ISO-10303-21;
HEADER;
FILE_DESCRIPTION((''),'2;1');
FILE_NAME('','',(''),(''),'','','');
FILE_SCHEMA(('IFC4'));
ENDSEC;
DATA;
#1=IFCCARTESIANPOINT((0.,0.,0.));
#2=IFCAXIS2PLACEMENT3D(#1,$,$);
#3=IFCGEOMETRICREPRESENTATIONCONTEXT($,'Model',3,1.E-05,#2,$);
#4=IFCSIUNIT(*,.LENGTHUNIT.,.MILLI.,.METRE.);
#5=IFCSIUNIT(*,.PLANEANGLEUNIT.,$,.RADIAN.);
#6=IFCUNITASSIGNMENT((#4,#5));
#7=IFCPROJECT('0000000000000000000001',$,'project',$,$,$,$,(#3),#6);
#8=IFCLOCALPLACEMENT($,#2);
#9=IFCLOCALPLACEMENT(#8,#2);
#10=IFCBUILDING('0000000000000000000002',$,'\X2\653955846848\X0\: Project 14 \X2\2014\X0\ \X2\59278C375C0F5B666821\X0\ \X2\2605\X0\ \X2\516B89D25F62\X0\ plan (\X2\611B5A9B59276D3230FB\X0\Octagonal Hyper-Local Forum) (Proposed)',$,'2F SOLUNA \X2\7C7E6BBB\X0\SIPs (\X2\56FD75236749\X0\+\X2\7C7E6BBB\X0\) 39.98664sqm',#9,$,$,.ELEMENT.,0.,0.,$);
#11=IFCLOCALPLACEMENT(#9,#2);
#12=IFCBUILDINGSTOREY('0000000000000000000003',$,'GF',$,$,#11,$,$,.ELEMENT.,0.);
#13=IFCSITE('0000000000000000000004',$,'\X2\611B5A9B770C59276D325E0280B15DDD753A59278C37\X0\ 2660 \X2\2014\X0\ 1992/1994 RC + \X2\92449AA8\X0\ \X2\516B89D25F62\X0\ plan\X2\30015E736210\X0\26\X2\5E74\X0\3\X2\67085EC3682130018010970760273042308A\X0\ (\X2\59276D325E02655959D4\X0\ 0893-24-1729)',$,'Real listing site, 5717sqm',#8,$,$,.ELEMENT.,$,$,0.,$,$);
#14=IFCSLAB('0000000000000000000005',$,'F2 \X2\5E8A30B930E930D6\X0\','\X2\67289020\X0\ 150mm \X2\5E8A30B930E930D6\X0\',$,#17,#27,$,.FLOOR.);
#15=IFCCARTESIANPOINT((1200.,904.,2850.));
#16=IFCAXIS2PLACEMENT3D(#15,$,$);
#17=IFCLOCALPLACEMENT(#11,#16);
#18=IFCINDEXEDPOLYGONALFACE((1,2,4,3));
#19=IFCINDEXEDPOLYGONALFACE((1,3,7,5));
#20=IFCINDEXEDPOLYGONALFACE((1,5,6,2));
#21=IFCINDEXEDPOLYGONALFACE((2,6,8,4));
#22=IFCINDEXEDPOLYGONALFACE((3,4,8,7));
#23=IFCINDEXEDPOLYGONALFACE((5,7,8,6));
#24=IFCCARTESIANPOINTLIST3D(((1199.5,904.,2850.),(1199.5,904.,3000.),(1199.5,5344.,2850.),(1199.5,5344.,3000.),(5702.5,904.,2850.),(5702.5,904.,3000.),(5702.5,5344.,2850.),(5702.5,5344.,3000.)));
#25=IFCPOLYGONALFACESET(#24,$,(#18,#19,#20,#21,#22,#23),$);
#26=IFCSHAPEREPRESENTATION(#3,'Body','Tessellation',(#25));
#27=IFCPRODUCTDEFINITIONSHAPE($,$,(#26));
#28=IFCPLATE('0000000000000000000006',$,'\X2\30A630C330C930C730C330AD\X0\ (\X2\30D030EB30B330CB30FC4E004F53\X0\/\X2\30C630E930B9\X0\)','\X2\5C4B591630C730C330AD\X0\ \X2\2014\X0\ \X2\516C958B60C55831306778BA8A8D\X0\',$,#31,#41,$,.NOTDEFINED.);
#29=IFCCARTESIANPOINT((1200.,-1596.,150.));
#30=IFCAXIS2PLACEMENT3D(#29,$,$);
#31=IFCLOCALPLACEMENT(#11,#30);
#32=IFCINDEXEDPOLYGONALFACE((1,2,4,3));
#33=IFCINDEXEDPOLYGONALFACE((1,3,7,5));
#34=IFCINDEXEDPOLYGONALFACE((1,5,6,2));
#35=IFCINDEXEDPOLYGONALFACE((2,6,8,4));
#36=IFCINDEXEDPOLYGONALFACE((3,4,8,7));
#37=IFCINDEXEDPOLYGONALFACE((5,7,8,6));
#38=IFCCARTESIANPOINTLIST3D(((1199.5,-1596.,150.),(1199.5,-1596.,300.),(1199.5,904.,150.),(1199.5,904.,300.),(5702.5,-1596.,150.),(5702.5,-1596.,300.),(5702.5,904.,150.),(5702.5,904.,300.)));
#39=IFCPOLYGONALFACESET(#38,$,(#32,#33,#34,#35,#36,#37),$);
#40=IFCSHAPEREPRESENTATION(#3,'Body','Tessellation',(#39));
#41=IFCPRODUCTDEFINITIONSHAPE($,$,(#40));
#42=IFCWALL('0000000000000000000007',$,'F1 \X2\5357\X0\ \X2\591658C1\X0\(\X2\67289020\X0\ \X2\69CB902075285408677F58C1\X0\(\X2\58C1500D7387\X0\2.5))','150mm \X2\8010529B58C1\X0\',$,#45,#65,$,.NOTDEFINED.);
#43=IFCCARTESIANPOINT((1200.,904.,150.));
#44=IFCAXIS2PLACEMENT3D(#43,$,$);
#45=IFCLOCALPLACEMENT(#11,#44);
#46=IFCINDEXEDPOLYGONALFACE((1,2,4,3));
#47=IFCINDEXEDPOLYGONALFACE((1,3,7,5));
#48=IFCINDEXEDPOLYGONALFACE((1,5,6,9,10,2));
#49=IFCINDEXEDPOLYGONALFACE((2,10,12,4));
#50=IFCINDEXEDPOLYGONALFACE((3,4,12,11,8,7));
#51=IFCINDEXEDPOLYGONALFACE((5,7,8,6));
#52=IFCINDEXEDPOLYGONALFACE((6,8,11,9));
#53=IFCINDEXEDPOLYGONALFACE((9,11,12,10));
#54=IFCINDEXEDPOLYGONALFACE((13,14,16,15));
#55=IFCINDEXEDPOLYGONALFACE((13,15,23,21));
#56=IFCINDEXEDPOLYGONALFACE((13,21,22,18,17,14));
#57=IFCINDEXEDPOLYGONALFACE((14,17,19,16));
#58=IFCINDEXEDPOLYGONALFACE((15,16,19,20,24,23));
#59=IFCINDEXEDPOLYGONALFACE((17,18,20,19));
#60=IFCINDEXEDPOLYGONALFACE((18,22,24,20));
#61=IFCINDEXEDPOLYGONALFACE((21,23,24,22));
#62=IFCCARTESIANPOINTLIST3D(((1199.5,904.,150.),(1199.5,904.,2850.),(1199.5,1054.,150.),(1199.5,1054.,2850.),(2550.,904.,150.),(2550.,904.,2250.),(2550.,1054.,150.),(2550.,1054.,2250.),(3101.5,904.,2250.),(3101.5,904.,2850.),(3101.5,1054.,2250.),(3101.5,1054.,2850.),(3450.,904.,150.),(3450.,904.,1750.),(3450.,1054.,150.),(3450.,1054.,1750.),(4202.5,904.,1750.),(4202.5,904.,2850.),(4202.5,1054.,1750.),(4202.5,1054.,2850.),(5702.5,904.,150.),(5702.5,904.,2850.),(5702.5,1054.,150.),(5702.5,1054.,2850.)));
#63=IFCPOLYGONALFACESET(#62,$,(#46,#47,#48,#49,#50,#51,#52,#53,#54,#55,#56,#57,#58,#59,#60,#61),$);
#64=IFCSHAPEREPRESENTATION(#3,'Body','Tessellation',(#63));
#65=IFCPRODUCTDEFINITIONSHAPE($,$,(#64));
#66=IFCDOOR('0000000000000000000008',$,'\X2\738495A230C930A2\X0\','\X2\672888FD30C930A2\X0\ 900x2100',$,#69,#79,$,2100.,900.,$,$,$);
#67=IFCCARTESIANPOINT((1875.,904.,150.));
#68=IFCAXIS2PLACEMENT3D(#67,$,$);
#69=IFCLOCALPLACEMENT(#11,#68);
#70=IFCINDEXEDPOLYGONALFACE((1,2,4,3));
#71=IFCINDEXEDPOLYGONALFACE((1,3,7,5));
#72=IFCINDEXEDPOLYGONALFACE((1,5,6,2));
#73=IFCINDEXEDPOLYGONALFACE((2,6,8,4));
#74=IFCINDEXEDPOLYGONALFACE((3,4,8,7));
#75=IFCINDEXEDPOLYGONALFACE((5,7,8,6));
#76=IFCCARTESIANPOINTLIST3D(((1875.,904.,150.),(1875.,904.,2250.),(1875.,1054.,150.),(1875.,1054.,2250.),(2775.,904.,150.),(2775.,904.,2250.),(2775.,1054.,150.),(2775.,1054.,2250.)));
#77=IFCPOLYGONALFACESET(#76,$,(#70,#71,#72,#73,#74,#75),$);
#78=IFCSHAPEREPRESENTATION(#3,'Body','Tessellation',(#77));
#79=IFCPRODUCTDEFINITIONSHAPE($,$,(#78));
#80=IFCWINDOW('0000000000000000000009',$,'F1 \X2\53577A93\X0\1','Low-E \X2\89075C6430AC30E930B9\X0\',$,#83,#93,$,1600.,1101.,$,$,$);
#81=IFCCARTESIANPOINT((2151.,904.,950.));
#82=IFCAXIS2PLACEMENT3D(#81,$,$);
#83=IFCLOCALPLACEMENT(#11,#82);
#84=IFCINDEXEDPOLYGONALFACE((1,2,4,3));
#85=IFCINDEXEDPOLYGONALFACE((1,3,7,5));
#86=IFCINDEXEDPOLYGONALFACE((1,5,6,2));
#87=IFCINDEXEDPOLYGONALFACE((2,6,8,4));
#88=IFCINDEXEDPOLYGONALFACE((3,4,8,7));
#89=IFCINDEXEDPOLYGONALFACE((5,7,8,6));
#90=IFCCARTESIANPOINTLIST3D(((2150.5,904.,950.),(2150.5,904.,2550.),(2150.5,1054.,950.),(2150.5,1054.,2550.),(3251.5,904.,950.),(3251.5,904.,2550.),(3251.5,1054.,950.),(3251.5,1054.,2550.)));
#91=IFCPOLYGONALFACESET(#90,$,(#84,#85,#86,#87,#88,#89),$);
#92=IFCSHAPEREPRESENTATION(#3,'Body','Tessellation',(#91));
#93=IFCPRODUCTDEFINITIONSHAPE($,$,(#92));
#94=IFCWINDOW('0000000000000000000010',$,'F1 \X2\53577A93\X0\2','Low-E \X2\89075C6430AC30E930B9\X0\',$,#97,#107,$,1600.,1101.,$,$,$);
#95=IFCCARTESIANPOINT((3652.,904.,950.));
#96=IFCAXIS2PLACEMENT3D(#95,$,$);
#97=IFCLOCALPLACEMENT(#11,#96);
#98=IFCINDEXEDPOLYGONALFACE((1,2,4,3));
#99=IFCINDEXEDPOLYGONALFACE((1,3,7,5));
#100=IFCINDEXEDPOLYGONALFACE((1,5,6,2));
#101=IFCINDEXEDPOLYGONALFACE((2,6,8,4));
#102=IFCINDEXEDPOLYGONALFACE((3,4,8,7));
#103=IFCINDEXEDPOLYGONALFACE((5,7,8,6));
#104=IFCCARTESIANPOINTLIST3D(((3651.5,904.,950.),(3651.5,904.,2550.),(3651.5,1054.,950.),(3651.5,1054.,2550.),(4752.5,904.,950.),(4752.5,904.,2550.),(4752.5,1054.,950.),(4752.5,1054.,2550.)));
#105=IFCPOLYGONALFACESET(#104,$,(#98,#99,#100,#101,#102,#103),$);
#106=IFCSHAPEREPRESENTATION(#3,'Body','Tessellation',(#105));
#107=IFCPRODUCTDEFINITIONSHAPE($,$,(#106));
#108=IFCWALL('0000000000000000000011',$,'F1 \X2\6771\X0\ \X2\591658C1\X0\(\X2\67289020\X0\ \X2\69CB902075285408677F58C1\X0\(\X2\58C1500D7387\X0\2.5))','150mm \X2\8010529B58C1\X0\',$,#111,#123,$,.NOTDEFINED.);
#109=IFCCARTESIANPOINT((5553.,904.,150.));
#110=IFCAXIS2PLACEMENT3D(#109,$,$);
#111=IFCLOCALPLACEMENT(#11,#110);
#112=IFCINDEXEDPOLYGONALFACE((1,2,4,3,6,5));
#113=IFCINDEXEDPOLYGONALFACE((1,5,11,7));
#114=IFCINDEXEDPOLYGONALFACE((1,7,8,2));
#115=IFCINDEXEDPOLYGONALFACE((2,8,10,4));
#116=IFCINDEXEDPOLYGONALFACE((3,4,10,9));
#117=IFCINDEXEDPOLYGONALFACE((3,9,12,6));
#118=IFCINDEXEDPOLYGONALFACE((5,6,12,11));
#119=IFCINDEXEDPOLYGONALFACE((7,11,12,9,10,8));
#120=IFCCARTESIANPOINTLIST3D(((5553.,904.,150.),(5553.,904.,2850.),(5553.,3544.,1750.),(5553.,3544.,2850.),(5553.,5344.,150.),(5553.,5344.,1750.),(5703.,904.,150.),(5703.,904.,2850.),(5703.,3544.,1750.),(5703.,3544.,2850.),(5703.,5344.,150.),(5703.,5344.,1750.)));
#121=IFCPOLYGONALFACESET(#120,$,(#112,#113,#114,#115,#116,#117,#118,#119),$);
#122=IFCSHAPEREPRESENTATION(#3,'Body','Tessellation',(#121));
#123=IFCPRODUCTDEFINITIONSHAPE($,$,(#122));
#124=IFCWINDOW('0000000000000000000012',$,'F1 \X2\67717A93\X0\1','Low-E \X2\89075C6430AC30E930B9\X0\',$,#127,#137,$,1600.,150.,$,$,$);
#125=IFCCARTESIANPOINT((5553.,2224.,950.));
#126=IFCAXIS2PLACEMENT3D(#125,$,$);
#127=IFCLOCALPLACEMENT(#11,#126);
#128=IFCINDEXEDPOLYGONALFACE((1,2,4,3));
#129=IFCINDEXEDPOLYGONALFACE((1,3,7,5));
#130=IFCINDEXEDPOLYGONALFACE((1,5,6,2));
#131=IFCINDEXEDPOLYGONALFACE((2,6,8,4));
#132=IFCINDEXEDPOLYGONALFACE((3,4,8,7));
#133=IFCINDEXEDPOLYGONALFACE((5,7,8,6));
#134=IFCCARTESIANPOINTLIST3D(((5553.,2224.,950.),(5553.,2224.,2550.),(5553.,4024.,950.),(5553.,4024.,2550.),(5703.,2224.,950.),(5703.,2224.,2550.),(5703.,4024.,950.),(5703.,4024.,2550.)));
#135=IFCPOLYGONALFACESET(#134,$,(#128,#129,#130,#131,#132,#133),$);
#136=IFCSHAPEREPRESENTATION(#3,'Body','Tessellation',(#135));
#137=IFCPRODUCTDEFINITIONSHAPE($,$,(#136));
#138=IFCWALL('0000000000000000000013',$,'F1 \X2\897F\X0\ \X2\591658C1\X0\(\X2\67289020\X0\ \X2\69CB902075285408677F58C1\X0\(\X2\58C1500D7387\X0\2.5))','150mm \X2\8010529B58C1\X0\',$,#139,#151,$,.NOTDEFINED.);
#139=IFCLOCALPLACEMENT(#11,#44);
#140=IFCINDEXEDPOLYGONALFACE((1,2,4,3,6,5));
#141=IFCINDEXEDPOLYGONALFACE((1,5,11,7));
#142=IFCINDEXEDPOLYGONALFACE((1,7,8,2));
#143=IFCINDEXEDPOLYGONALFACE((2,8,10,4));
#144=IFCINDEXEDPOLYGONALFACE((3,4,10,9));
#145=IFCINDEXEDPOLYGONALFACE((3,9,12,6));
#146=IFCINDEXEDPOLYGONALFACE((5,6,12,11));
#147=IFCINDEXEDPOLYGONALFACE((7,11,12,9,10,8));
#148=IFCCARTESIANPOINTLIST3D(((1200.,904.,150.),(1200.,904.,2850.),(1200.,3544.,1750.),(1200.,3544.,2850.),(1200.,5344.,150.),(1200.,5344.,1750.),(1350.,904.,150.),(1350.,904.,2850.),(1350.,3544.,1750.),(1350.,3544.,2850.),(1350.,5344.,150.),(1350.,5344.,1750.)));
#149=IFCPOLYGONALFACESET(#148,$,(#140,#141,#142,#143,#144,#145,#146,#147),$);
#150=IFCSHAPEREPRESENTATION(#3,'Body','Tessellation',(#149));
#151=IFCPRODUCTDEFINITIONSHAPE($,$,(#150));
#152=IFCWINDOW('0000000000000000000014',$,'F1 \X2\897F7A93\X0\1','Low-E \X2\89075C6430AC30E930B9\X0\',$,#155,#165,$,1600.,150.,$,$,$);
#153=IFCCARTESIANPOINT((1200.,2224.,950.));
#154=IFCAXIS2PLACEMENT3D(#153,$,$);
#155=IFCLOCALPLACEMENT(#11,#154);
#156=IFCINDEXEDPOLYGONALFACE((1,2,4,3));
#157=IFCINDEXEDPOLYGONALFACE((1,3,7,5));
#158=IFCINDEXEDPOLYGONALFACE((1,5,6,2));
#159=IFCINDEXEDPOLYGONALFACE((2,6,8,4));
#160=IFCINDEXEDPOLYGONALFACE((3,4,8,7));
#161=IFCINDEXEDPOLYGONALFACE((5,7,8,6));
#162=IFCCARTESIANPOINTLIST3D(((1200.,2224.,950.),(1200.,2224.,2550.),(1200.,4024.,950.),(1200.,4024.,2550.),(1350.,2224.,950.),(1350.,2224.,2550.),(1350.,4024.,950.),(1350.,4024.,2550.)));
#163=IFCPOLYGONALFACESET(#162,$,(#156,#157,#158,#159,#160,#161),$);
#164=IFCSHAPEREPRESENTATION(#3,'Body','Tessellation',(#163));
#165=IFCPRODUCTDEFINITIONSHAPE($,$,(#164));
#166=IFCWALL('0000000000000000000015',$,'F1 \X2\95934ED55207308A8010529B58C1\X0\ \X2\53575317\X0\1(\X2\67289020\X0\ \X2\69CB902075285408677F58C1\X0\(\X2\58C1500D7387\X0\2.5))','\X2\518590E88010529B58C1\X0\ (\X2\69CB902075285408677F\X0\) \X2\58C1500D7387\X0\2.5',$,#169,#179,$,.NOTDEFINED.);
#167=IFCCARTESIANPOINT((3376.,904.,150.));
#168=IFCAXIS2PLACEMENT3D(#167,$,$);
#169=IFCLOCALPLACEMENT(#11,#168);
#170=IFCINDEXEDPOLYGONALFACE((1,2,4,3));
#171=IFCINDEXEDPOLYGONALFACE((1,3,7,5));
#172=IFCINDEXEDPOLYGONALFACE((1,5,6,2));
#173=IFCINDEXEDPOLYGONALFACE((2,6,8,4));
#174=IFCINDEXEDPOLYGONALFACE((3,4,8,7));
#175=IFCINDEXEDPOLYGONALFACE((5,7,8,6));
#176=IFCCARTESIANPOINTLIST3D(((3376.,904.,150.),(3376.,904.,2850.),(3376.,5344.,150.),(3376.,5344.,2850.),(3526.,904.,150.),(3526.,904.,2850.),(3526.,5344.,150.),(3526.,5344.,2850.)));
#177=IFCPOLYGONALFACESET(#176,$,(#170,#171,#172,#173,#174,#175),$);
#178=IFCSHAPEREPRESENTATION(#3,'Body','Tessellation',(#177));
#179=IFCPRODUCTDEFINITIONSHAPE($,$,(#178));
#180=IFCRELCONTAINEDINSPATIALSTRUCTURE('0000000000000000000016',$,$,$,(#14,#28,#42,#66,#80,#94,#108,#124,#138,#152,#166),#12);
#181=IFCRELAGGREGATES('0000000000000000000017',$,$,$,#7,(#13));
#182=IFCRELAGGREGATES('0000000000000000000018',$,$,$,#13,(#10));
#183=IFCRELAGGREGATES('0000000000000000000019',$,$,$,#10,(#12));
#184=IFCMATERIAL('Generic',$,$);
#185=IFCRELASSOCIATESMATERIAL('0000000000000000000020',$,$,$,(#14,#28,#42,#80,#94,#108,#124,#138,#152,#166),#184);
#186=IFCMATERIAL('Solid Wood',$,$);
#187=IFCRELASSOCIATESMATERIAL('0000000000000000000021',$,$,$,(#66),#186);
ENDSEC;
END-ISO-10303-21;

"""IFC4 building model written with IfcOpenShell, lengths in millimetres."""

from ifc_helpers import new_model, si_unit, frame, frame_2d, origin, place, context, project, spatial, rectangle, extrude, material, element, fill, save


model = new_model("IFC4")

# Units and contexts
model_context = context("Model", 3, precision=1e-05, world=origin())
ifc_project = project(units=[si_unit("LENGTHUNIT", "METRE", prefix="MILLI"), si_unit("PLANEANGLEUNIT", "RADIAN")], contexts=[model_context])

# Site, building, storey
site_placement = place(None, origin())
site = spatial("IfcSite", under=ifc_project, at=site_placement, Name="愛媛県大洲市肱川町大谷 2660 — 1992/1994 RC + 鉄骨 八角形 plan、平成26年3月廃校、耐震性あり (大洲市教委 0893-24-1729)", ObjectType="Real listing site, 5717sqm", CompositionType="ELEMENT", RefElevation=0.0)
building_placement = place(site_placement, origin())
building = spatial("IfcBuilding", under=site, at=building_placement, Name="改善案: Project 14 — 大谷小学校 ★ 八角形 plan (愛媛大洲・Octagonal Hyper-Local Forum) (Proposed)", ObjectType="2F SOLUNA 籾殻SIPs (国産杉+籾殻) 39.98664sqm", CompositionType="ELEMENT", ElevationOfRefHeight=0.0, ElevationOfTerrain=0.0)
storey_placement = place(building_placement, origin())
storey = spatial("IfcBuildingStorey", under=building, at=storey_placement, Name="GF", CompositionType="ELEMENT", Elevation=0.0)

# Slab
ifc_material_1 = material(Name="Generic")
slab_1_placement = place(storey_placement, frame((1200.0, 904.0, 2850.0)))
element("IfcSlab", 1, at=slab_1_placement, inside=storey, material=ifc_material_1, Name="F2 床スラブ", Description="木造 150mm 床スラブ", PredefinedType="FLOOR", context=model_context, shape_type="SweptSolid", body=[
    extrude(rectangle(XDim=4503.0, YDim=4440.0, at=frame_2d((2251.0, 2220.0))), frame((1200.0, 904.0, 2850.0)), (0.0, 0.0, 1.0), 150.0),
])

# Plate
plate_placement = place(storey_placement, frame((1200.0, -1596.0, 150.0)))
element("IfcPlate", 2, at=plate_placement, inside=storey, material=ifc_material_1, Name="ウッドデッキ (バルコニー一体/テラス)", Description="屋外デッキ — 公開情報で確認", PredefinedType="NOTDEFINED", context=model_context, shape_type="SweptSolid", body=[
    extrude(rectangle(XDim=4503.0, YDim=2500.0, at=frame_2d((2251.0, 1250.0))), frame((1200.0, -1596.0, 150.0)), (0.0, 0.0, 1.0), 150.0),
])

# Wall, openings, door, windows
wall_1_placement = place(storey_placement, frame((1200.0, 904.0, 150.0)))
wall_1 = element("IfcWall", 3, at=wall_1_placement, inside=storey, material=ifc_material_1, Name="F1 南 外壁(木造 構造用合板壁(壁倍率2.5))", Description="150mm 耐力壁", PredefinedType="NOTDEFINED", context=model_context, shape_type="SweptSolid", body=[
    extrude(rectangle(XDim=4503.0, YDim=150.0, at=frame_2d((2251.0, 75.0))), frame((1200.0, 904.0, 150.0)), (0.0, 0.0, 1.0), 2700.0),
])
opening_1_placement = place(storey_placement, frame((1875.0, 904.0, 150.0)))
opening_1 = element("IfcOpeningElement", 4, at=opening_1_placement, cuts=wall_1, PredefinedType="NOTDEFINED", context=model_context, shape_type="SweptSolid", body=[
    extrude(rectangle(XDim=900.0, YDim=150.0, at=frame_2d((450.0, 75.0))), frame((1875.0, 904.0, 150.0)), (0.0, 0.0, 1.0), 2100.0),
])
opening_2_placement = place(storey_placement, frame((2151.0, 904.0, 950.0)))
opening_2 = element("IfcOpeningElement", 5, at=opening_2_placement, cuts=wall_1, PredefinedType="NOTDEFINED", context=model_context, shape_type="SweptSolid", body=[
    extrude(rectangle(XDim=1101.0, YDim=150.0, at=frame_2d((550.0, 75.0))), frame((2151.0, 904.0, 950.0)), (0.0, 0.0, 1.0), 1600.0),
])
opening_3_placement = place(storey_placement, frame((3652.0, 904.0, 950.0)))
opening_3 = element("IfcOpeningElement", 6, at=opening_3_placement, cuts=wall_1, PredefinedType="NOTDEFINED", context=model_context, shape_type="SweptSolid", body=[
    extrude(rectangle(XDim=1101.0, YDim=150.0, at=frame_2d((550.0, 75.0))), frame((3652.0, 904.0, 950.0)), (0.0, 0.0, 1.0), 1600.0),
])
ifc_material_2 = material(Name="Solid Wood")
door_placement = place(storey_placement, frame((1875.0, 904.0, 150.0)))
door = element("IfcDoor", 7, at=door_placement, inside=storey, material=ifc_material_2, Name="玄関ドア", Description="木製ドア 900x2100", OverallHeight=2100.0, OverallWidth=900.0, context=model_context, shape_type="SweptSolid", body=[
    extrude(rectangle(XDim=900.0, YDim=150.0, at=frame_2d((450.0, 75.0))), frame((1875.0, 904.0, 150.0)), (0.0, 0.0, 1.0), 2100.0),
])
fill(opening_1, door)
window_1_placement = place(storey_placement, frame((2151.0, 904.0, 950.0)))
window_1 = element("IfcWindow", 8, at=window_1_placement, inside=storey, material=ifc_material_1, Name="F1 南窓1", Description="Low-E 複層ガラス", OverallHeight=1600.0, OverallWidth=1101.0, context=model_context, shape_type="SweptSolid", body=[
    extrude(rectangle(XDim=1101.0, YDim=150.0, at=frame_2d((550.0, 75.0))), frame((2151.0, 904.0, 950.0)), (0.0, 0.0, 1.0), 1600.0),
])
fill(opening_2, window_1)
window_2_placement = place(storey_placement, frame((3652.0, 904.0, 950.0)))
window_2 = element("IfcWindow", 9, at=window_2_placement, inside=storey, material=ifc_material_1, Name="F1 南窓2", Description="Low-E 複層ガラス", OverallHeight=1600.0, OverallWidth=1101.0, context=model_context, shape_type="SweptSolid", body=[
    extrude(rectangle(XDim=1101.0, YDim=150.0, at=frame_2d((550.0, 75.0))), frame((3652.0, 904.0, 950.0)), (0.0, 0.0, 1.0), 1600.0),
])
fill(opening_3, window_2)

# Walls, openings, windows
wall_2_placement = place(storey_placement, frame((5553.0, 904.0, 150.0)))
wall_2 = element("IfcWall", 10, at=wall_2_placement, inside=storey, material=ifc_material_1, Name="F1 東 外壁(木造 構造用合板壁(壁倍率2.5))", Description="150mm 耐力壁", PredefinedType="NOTDEFINED", context=model_context, shape_type="SweptSolid", body=[
    extrude(rectangle(XDim=150.0, YDim=4440.0, at=frame_2d((75.0, 2220.0))), frame((5553.0, 904.0, 150.0)), (0.0, 0.0, 1.0), 2700.0),
])
opening_4_placement = place(storey_placement, frame((5553.0, 2224.0, 950.0)))
opening_4 = element("IfcOpeningElement", 11, at=opening_4_placement, cuts=wall_2, PredefinedType="NOTDEFINED", context=model_context, shape_type="SweptSolid", body=[
    extrude(rectangle(XDim=150.0, YDim=1800.0, at=frame_2d((75.0, 900.0))), frame((5553.0, 2224.0, 950.0)), (0.0, 0.0, 1.0), 1600.0),
])
window_3_placement = place(storey_placement, frame((5553.0, 2224.0, 950.0)))
window_3 = element("IfcWindow", 12, at=window_3_placement, inside=storey, material=ifc_material_1, Name="F1 東窓1", Description="Low-E 複層ガラス", OverallHeight=1600.0, OverallWidth=150.0, context=model_context, shape_type="SweptSolid", body=[
    extrude(rectangle(XDim=150.0, YDim=1800.0, at=frame_2d((75.0, 900.0))), frame((5553.0, 2224.0, 950.0)), (0.0, 0.0, 1.0), 1600.0),
])
fill(opening_4, window_3)
wall_3_placement = place(storey_placement, frame((1200.0, 904.0, 150.0)))
wall_3 = element("IfcWall", 13, at=wall_3_placement, inside=storey, material=ifc_material_1, Name="F1 西 外壁(木造 構造用合板壁(壁倍率2.5))", Description="150mm 耐力壁", PredefinedType="NOTDEFINED", context=model_context, shape_type="SweptSolid", body=[
    extrude(rectangle(XDim=150.0, YDim=4440.0, at=frame_2d((75.0, 2220.0))), frame((1200.0, 904.0, 150.0)), (0.0, 0.0, 1.0), 2700.0),
])
opening_5_placement = place(storey_placement, frame((1200.0, 2224.0, 950.0)))
opening_5 = element("IfcOpeningElement", 14, at=opening_5_placement, cuts=wall_3, PredefinedType="NOTDEFINED", context=model_context, shape_type="SweptSolid", body=[
    extrude(rectangle(XDim=150.0, YDim=1800.0, at=frame_2d((75.0, 900.0))), frame((1200.0, 2224.0, 950.0)), (0.0, 0.0, 1.0), 1600.0),
])
window_4_placement = place(storey_placement, frame((1200.0, 2224.0, 950.0)))
window_4 = element("IfcWindow", 15, at=window_4_placement, inside=storey, material=ifc_material_1, Name="F1 西窓1", Description="Low-E 複層ガラス", OverallHeight=1600.0, OverallWidth=150.0, context=model_context, shape_type="SweptSolid", body=[
    extrude(rectangle(XDim=150.0, YDim=1800.0, at=frame_2d((75.0, 900.0))), frame((1200.0, 2224.0, 950.0)), (0.0, 0.0, 1.0), 1600.0),
])
fill(opening_5, window_4)

# Wall
wall_4_placement = place(storey_placement, frame((3376.0, 904.0, 150.0)))
element("IfcWall", 16, at=wall_4_placement, inside=storey, material=ifc_material_1, Name="F1 間仕切り耐力壁 南北1(木造 構造用合板壁(壁倍率2.5))", Description="内部耐力壁 (構造用合板) 壁倍率2.5", PredefinedType="NOTDEFINED", context=model_context, shape_type="SweptSolid", body=[
    extrude(rectangle(XDim=150.0, YDim=4440.0, at=frame_2d((75.0, 2220.0))), frame((3376.0, 904.0, 150.0)), (0.0, 0.0, 1.0), 2700.0),
])

save(model, "model.ifc")
